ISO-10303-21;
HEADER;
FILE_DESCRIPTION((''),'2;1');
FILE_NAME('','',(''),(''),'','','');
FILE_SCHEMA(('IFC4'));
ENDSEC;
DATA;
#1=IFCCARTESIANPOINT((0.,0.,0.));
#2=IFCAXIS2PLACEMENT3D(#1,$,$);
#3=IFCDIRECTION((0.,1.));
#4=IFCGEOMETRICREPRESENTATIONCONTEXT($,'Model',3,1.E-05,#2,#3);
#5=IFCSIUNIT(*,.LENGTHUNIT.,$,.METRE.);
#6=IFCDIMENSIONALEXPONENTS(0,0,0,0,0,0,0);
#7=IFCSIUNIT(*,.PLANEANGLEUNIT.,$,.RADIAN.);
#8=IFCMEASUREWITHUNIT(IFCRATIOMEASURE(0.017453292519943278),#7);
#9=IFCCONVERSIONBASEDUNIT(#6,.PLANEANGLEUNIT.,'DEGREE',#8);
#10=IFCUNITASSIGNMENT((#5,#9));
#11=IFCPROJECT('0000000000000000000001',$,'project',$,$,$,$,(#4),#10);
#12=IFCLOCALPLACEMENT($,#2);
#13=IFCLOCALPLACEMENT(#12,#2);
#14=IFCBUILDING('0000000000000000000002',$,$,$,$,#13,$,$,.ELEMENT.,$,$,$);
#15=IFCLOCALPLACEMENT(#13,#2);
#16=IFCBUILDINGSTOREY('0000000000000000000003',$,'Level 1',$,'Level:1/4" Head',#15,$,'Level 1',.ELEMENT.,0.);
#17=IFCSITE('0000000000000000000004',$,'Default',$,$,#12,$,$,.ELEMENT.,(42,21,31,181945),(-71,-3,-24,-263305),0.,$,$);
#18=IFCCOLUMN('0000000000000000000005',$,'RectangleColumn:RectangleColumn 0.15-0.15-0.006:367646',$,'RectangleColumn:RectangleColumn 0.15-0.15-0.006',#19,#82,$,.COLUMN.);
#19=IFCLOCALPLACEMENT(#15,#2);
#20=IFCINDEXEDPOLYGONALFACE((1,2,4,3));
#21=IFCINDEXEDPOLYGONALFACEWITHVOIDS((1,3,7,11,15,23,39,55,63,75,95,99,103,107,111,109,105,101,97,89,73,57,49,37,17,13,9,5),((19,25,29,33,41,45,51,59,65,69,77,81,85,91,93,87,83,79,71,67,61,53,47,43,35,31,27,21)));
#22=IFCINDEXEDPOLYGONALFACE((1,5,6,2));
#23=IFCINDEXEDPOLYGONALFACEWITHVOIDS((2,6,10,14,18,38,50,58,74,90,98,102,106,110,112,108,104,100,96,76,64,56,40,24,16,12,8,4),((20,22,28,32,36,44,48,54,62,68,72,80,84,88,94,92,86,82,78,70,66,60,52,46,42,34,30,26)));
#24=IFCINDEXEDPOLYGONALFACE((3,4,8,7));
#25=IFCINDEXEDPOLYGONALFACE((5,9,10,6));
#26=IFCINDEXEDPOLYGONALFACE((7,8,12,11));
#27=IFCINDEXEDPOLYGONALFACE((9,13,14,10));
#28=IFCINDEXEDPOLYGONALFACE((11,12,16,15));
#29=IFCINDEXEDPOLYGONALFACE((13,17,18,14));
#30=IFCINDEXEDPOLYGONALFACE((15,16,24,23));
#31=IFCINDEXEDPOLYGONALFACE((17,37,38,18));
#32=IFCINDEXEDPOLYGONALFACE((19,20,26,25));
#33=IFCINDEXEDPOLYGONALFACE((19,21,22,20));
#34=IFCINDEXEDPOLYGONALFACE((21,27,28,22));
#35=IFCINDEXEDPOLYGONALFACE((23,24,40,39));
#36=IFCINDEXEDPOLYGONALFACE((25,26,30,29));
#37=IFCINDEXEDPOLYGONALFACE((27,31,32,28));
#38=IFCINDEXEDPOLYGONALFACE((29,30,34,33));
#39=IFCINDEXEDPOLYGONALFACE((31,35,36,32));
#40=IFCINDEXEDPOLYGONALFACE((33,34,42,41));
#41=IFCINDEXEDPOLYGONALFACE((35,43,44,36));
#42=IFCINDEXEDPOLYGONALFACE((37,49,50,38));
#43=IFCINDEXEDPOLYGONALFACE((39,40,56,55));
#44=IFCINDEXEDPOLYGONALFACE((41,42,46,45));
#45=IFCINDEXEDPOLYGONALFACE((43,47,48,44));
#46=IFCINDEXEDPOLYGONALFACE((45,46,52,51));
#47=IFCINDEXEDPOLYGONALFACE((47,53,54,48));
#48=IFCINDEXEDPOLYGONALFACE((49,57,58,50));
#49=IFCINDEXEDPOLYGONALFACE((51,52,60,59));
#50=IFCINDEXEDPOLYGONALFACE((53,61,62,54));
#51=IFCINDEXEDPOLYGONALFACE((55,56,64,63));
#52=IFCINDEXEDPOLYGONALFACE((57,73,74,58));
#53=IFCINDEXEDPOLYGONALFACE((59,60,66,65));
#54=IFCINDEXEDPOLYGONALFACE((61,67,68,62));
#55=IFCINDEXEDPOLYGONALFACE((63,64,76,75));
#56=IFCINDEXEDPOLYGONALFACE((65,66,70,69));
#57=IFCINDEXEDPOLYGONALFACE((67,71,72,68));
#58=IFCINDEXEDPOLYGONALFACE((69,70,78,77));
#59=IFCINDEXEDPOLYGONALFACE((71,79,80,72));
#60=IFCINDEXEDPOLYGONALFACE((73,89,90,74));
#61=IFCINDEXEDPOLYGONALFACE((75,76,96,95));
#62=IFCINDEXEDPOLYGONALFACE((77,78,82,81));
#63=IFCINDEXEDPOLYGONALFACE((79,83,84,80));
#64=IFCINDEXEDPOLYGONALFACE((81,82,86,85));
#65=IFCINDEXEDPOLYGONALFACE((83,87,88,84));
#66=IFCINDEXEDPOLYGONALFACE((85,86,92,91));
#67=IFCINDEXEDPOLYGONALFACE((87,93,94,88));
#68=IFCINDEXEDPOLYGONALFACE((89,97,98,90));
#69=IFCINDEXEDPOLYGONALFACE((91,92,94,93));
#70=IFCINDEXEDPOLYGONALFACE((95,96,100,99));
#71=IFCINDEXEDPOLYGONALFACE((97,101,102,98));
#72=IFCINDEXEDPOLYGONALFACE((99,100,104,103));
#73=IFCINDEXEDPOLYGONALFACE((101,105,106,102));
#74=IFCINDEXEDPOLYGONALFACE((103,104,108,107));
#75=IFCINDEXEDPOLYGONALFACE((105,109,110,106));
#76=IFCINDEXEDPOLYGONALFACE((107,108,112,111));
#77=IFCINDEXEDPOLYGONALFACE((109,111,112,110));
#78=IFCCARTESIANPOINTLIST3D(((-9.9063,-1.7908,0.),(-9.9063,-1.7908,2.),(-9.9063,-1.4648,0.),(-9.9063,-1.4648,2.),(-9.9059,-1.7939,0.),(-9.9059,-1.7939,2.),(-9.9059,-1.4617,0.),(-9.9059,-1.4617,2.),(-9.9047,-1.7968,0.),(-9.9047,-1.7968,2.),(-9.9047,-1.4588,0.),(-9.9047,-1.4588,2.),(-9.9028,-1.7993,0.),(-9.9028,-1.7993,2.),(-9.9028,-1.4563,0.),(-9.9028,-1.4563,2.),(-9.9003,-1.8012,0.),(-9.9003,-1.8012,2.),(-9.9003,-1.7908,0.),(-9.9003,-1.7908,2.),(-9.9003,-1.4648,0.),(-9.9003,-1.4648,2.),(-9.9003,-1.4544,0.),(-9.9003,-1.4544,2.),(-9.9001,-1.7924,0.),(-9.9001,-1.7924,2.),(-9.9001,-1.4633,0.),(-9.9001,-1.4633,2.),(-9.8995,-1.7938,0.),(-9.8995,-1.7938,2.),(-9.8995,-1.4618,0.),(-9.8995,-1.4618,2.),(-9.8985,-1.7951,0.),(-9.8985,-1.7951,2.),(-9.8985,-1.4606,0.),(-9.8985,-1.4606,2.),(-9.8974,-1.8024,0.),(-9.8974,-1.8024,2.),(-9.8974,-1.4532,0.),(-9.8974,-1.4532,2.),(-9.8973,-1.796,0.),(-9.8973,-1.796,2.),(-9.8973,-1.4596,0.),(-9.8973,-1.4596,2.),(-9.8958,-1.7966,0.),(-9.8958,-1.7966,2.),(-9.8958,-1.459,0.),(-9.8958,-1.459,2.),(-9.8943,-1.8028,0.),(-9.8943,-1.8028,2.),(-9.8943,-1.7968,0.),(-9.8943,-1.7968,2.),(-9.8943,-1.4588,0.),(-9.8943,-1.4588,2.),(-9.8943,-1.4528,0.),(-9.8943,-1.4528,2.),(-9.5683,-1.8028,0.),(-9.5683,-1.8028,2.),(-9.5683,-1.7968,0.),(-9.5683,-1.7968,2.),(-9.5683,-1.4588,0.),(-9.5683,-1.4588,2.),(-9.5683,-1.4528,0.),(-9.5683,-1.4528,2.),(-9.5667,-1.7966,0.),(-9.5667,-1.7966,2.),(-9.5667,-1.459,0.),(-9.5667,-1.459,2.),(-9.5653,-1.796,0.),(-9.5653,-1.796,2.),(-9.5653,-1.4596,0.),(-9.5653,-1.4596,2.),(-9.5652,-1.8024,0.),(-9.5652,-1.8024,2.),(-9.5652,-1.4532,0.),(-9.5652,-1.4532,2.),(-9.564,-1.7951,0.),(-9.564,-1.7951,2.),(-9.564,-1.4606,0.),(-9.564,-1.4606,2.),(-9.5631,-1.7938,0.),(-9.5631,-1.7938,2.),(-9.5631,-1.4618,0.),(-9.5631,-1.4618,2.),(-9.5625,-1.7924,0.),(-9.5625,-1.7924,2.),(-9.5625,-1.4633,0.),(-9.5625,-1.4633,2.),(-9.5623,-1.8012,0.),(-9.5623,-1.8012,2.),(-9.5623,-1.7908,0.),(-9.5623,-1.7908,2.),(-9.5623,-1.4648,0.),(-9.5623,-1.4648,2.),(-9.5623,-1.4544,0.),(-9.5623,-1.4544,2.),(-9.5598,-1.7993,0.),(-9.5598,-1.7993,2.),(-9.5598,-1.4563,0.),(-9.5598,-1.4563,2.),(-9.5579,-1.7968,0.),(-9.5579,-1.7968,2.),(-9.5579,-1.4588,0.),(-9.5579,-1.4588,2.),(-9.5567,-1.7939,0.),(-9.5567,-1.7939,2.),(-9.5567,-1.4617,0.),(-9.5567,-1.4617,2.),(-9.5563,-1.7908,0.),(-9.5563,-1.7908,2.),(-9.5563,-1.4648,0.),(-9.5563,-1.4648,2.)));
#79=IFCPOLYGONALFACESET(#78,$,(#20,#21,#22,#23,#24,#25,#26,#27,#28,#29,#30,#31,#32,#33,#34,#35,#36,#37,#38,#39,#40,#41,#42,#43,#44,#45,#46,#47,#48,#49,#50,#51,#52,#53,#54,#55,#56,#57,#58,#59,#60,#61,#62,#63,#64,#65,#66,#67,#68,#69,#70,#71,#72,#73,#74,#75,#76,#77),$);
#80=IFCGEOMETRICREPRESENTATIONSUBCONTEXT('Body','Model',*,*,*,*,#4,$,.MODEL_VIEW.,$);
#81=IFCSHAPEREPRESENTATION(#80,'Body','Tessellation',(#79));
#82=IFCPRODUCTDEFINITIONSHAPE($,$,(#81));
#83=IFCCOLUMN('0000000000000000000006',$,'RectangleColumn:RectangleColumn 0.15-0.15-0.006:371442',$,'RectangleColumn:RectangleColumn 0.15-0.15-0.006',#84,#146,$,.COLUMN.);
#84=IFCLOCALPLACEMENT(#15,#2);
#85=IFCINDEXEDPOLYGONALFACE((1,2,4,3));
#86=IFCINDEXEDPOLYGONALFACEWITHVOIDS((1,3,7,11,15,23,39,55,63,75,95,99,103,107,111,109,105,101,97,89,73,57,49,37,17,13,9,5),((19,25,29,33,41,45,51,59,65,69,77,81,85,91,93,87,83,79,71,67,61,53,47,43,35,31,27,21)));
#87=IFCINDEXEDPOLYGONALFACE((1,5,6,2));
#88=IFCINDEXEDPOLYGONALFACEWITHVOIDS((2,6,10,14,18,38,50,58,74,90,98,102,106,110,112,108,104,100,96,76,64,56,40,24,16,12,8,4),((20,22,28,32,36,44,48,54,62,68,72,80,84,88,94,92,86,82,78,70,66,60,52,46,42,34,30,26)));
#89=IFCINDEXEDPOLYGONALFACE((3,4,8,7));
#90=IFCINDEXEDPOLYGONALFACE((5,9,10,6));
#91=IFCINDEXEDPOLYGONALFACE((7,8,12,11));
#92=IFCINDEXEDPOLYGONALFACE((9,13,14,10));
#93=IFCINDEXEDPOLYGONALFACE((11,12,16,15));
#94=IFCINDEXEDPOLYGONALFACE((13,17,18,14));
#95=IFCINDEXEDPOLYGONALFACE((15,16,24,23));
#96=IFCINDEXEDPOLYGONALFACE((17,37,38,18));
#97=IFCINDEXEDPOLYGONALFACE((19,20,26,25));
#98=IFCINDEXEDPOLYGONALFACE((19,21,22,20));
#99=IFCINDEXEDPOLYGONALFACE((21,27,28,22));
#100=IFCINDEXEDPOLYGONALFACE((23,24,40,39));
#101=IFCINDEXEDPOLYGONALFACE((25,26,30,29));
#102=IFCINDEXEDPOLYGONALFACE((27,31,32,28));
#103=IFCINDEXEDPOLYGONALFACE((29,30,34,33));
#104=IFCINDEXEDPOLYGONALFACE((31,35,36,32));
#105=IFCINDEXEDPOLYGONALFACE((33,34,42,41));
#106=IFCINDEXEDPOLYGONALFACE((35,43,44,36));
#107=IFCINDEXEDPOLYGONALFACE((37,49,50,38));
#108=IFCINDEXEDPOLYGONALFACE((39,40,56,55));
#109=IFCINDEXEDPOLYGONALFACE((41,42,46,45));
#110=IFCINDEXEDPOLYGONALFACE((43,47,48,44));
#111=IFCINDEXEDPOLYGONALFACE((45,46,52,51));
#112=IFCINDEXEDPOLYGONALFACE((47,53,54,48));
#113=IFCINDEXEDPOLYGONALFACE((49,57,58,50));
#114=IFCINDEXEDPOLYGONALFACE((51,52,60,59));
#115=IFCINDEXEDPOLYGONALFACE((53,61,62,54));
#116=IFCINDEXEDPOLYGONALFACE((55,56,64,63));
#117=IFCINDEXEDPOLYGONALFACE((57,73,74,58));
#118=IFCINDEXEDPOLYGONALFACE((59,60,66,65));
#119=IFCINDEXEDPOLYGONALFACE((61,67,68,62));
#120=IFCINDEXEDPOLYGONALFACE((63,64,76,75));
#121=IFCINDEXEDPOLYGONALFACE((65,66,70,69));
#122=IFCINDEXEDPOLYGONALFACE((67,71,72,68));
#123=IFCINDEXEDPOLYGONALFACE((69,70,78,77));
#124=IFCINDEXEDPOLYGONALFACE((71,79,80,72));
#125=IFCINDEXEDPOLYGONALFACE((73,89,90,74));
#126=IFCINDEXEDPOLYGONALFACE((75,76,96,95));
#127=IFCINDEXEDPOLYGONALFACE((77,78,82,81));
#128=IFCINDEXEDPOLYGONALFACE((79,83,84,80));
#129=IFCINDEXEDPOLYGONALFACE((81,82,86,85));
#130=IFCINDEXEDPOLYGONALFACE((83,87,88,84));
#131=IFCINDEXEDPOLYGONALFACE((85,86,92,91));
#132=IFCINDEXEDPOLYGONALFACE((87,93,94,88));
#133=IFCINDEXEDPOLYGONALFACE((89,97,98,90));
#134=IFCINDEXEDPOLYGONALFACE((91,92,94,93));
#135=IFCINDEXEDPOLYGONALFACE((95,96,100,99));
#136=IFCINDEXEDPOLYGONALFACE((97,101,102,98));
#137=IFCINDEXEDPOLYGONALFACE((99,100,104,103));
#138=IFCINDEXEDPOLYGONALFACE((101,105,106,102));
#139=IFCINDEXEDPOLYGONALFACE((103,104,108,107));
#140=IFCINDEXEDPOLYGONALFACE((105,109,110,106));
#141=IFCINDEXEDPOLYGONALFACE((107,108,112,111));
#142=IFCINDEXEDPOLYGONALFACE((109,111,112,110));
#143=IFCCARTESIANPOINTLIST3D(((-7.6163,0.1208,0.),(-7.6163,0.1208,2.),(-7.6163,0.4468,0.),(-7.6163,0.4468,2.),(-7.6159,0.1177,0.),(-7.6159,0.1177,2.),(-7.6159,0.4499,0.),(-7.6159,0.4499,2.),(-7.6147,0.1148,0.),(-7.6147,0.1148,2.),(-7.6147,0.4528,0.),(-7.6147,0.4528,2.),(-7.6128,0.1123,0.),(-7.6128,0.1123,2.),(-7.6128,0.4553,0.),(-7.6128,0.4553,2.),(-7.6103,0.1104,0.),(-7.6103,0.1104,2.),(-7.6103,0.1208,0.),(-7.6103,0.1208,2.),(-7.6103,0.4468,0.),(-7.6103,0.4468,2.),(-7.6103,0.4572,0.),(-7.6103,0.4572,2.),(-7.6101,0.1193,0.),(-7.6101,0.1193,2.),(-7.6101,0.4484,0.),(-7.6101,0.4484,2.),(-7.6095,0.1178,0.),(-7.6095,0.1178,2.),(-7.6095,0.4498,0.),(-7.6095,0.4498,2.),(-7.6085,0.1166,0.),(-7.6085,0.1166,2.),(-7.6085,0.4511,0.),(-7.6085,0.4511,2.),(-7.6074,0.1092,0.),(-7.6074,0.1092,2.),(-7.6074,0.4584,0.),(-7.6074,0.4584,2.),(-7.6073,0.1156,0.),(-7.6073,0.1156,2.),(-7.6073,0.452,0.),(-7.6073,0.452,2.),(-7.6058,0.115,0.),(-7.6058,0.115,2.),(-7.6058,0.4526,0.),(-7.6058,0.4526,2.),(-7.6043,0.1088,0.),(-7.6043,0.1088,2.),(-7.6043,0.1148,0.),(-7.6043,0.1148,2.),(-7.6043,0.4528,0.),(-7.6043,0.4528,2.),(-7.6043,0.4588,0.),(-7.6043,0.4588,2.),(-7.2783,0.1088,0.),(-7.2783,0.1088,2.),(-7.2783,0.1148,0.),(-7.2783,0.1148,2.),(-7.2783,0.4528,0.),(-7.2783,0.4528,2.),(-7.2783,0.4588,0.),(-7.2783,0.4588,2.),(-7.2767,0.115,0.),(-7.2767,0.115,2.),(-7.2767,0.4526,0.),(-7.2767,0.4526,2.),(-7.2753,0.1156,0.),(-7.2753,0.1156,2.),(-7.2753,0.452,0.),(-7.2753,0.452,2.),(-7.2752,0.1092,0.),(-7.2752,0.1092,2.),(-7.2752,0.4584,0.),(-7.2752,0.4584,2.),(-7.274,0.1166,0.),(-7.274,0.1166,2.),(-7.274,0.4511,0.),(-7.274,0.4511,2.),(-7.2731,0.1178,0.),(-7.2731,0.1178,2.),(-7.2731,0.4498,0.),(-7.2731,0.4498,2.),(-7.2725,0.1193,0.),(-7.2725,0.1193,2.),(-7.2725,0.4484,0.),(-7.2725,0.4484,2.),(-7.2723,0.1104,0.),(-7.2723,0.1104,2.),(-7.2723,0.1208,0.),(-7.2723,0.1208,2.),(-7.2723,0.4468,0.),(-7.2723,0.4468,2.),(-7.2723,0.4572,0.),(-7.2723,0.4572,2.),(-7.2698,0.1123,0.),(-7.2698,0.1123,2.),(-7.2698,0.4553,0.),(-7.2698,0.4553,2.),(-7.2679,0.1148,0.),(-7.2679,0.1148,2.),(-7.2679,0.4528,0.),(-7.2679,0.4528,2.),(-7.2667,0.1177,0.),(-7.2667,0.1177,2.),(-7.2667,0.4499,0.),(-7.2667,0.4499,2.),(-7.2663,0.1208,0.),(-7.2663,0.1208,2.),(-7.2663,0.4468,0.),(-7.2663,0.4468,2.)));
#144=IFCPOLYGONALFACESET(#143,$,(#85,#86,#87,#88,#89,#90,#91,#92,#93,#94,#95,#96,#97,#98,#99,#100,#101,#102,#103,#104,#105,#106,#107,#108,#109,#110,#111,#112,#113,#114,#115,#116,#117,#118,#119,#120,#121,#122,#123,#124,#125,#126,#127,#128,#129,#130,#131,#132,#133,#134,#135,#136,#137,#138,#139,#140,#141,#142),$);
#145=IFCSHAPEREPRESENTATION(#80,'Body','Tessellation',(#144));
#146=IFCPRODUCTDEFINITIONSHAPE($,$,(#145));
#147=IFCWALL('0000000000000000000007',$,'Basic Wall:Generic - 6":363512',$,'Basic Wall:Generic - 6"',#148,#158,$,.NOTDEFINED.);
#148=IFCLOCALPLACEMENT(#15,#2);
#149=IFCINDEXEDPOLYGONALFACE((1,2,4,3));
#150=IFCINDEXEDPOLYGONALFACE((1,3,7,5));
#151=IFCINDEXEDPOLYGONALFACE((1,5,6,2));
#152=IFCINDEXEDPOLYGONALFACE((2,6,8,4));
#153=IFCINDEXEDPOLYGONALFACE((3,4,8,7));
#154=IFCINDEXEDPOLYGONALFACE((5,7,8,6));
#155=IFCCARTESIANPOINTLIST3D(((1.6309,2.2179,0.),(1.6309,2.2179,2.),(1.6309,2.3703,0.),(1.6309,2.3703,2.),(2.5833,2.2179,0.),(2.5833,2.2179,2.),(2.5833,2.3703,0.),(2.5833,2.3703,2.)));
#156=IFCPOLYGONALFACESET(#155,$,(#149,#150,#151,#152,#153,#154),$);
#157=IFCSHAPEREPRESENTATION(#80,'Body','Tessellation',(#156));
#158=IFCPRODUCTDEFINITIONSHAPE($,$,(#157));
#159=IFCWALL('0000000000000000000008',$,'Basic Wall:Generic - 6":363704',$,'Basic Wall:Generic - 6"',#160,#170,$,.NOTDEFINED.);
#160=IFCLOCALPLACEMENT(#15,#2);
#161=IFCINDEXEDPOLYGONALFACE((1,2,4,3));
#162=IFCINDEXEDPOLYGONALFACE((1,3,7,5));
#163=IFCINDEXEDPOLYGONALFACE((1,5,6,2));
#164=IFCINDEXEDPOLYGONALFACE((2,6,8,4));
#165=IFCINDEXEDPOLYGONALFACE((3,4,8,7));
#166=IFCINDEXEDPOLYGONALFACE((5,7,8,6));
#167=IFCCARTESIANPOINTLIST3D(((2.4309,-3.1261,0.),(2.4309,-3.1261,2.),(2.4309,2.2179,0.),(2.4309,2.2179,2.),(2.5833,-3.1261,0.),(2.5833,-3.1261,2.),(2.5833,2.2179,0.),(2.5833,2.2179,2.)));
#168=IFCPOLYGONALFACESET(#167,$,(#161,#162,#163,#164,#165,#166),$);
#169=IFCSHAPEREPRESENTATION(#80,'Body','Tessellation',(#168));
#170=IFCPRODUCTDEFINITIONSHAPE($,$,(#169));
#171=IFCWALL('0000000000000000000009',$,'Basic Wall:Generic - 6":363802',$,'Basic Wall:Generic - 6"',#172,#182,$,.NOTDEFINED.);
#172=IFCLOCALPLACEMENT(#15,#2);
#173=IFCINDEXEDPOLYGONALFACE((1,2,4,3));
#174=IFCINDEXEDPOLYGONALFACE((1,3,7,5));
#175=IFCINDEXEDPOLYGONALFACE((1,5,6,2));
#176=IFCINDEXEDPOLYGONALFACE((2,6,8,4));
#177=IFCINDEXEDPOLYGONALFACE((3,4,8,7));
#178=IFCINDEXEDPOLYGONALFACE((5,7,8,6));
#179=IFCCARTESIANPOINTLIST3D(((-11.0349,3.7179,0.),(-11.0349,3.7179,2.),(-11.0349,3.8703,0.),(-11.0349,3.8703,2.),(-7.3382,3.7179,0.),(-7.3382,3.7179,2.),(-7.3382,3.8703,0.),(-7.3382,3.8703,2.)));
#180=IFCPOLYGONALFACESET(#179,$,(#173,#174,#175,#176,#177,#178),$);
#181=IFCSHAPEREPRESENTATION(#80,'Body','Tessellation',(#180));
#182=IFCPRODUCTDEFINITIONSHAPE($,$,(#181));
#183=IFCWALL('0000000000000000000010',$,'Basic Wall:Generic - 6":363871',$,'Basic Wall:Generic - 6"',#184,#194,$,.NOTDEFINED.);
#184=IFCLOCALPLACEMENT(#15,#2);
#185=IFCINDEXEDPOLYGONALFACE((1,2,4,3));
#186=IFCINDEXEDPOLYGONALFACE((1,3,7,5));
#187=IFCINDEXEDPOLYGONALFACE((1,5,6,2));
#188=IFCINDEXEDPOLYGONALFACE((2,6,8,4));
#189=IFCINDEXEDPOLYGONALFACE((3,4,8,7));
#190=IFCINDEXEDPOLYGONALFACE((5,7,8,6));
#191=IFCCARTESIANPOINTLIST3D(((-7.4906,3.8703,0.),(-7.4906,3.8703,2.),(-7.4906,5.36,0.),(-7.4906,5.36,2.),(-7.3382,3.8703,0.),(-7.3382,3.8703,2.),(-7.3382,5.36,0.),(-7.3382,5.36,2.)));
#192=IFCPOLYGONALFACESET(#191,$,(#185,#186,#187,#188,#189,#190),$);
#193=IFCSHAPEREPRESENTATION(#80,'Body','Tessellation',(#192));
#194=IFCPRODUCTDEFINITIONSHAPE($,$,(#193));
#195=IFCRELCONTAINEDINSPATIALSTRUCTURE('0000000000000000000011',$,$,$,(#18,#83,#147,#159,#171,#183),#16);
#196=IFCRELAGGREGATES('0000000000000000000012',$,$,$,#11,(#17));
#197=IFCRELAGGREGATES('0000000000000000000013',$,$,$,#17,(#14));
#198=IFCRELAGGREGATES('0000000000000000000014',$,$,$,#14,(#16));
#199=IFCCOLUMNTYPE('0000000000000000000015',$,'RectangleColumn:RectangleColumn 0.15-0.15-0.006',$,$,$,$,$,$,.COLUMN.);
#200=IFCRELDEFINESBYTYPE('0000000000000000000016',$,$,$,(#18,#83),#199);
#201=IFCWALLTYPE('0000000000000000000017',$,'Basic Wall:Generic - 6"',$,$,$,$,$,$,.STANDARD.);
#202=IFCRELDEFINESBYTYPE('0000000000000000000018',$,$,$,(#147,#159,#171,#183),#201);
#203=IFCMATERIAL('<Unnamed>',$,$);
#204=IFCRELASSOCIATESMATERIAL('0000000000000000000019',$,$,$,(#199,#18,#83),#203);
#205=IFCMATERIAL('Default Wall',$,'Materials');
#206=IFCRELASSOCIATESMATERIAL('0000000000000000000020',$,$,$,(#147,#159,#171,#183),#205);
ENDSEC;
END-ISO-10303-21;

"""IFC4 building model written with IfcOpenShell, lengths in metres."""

from ifc_helpers import new_model, entity, si_unit, converted_unit, direction, frame, origin, place, context, subcontext, project, spatial, line, arc, indexed_curve, outline, extrude, source, transform, mapped, material, type_object, type_shapes, element, save


model = new_model("IFC4")

# Units and contexts
model_context = context("Model", 3, precision=1e-05, world=origin(), true_north=direction((0.0, 1.0)))
body_context = subcontext(model_context, "Body", "Model", "MODEL_VIEW")
ifc_project = project(units=[si_unit("LENGTHUNIT", "METRE"), converted_unit("PLANEANGLEUNIT", "DEGREE", entity("IfcRatioMeasure", 0.017453292519943278), si_unit("PLANEANGLEUNIT", "RADIAN"), dimensions=[0, 0, 0, 0, 0, 0, 0])], contexts=[model_context])

# Site, building, storey
site_placement = place(None, origin())
site = spatial("IfcSite", under=ifc_project, at=site_placement, Name="Default", CompositionType="ELEMENT", RefLatitude=(42, 21, 31, 181945), RefLongitude=(-71, -3, -24, -263305), RefElevation=0.0)
building_placement = place(site_placement, origin())
building = spatial("IfcBuilding", under=site, at=building_placement, CompositionType="ELEMENT")
storey_placement = place(building_placement, origin())
storey = spatial("IfcBuildingStorey", under=building, at=storey_placement, Name="Level 1", ObjectType="Level:1/4\" Head", LongName="Level 1", CompositionType="ELEMENT", Elevation=0.0)

# Columns
ifc_material_1 = material(Name="<Unnamed>")
column_type = type_object("IfcColumnType", Name="RectangleColumn:RectangleColumn 0.15-0.15-0.006", PredefinedType="COLUMN", material=ifc_material_1)
shared_shape = source(origin(), body_context, "Body", "SweptSolid", [
    extrude(outline(indexed_curve([(-0.163, -0.175), (0.163, -0.175), (0.1715, -0.1715), (0.175, -0.163), (0.175, 0.163), (0.1715, 0.1715), (0.163, 0.175), (-0.163, 0.175), (-0.1715, 0.1715), (-0.175, 0.163), (-0.175, -0.163), (-0.1715, -0.1715)], segments=[line(1, 2), arc(2, 3, 4), line(4, 5), arc(5, 6, 7), line(7, 8), arc(8, 9, 10), line(10, 11), arc(11, 12, 1)], self_intersect=False), holes=[indexed_curve([(-0.163, -0.169), (-0.1672, -0.1672), (-0.169, -0.163), (-0.169, 0.163), (-0.1672, 0.1672), (-0.163, 0.169), (0.163, 0.169), (0.1672, 0.1672), (0.169, 0.163), (0.169, -0.163), (0.1672, -0.1672), (0.163, -0.169)], segments=[arc(1, 2, 3), line(3, 4), arc(4, 5, 6), line(6, 7), arc(7, 8, 9), line(9, 10), arc(10, 11, 12), line(12, 1)], self_intersect=False)]), frame((0.0, 0.0, 0.0), z_axis=(0.0, 0.0, 1.0), x_axis=(-1.0, 0.0, 0.0)), (0.0, 0.0, 1.0), 2.0),
])
type_shapes(column_type, [shared_shape])
for number, where, name in (
    (1, (-9.7313, -1.6278, 0.0), "RectangleColumn:RectangleColumn 0.15-0.15-0.006:367646"),
    (2, (-7.4413, 0.2838, 0.0), "RectangleColumn:RectangleColumn 0.15-0.15-0.006:371442"),
):
    element("IfcColumn", number, at=place(storey_placement, frame(where)), inside=storey, type_object=column_type, material=ifc_material_1, Name=name, ObjectType="RectangleColumn:RectangleColumn 0.15-0.15-0.006", PredefinedType="COLUMN", context=body_context, shape_type="MappedRepresentation", body=[
        mapped(shared_shape, transform((0.0, 0.0, 0.0), scale=1.0)),
    ])

# Walls
ifc_material_2 = material(Name="Default Wall", Category="Materials")
wall_type_1 = type_object("IfcWallType", Name="Basic Wall:Generic - 6\"", PredefinedType="STANDARD")
wall_1_placement = place(storey_placement, frame((2.5833, 2.2941, 0.0), z_axis=(0.0, 0.0, 1.0), x_axis=(-1.0, 0.0, 0.0)))
element("IfcWall", 3, at=wall_1_placement, inside=storey, type_object=wall_type_1, material=ifc_material_2, Name="Basic Wall:Generic - 6\":363512", ObjectType="Basic Wall:Generic - 6\"", PredefinedType="NOTDEFINED", context=body_context, shape_type="SweptSolid", body=[
    extrude(outline(indexed_curve([(0.9524, 0.0762), (0.0, 0.0762), (0.0, -0.0762), (0.9524, -0.0762), (0.9524, 0.0762)], self_intersect=False)), origin(), (0.0, 0.0, 1.0), 2.0),
])
wall_2_placement = place(storey_placement, frame((2.5071, -3.1261, 0.0), z_axis=(0.0, 0.0, 1.0), x_axis=(0.0, 1.0, 0.0)))
element("IfcWall", 4, at=wall_2_placement, inside=storey, type_object=wall_type_1, material=ifc_material_2, Name="Basic Wall:Generic - 6\":363704", ObjectType="Basic Wall:Generic - 6\"", PredefinedType="NOTDEFINED", context=body_context, shape_type="SweptSolid", body=[
    extrude(outline(indexed_curve([(5.344, 0.0762), (0.0, 0.0762), (0.0, -0.0762), (5.344, -0.0762), (5.344, 0.0762)], self_intersect=False)), origin(), (0.0, 0.0, 1.0), 2.0),
])
wall_3_placement = place(storey_placement, frame((-7.3382, 3.7941, 0.0), z_axis=(0.0, 0.0, 1.0), x_axis=(-1.0, 0.0, 0.0)))
element("IfcWall", 5, at=wall_3_placement, inside=storey, type_object=wall_type_1, material=ifc_material_2, Name="Basic Wall:Generic - 6\":363802", ObjectType="Basic Wall:Generic - 6\"", PredefinedType="NOTDEFINED", context=body_context, shape_type="SweptSolid", body=[
    extrude(outline(indexed_curve([(3.6968, 0.0762), (0.0, 0.0762), (0.0, -0.0762), (3.6968, -0.0762), (3.6968, 0.0762)], self_intersect=False)), origin(), (0.0, 0.0, 1.0), 2.0),
])
wall_4_placement = place(storey_placement, frame((-7.4144, 5.36, 0.0), z_axis=(0.0, 0.0, 1.0), x_axis=(0.0, -1.0, 0.0)))
element("IfcWall", 6, at=wall_4_placement, inside=storey, type_object=wall_type_1, material=ifc_material_2, Name="Basic Wall:Generic - 6\":363871", ObjectType="Basic Wall:Generic - 6\"", PredefinedType="NOTDEFINED", context=body_context, shape_type="SweptSolid", body=[
    extrude(outline(indexed_curve([(1.4897, 0.0762), (0.0, 0.0762), (0.0, -0.0762), (1.4897, -0.0762), (1.4897, 0.0762)], self_intersect=False)), origin(), (0.0, 0.0, 1.0), 2.0),
])

save(model, "model.ifc")
